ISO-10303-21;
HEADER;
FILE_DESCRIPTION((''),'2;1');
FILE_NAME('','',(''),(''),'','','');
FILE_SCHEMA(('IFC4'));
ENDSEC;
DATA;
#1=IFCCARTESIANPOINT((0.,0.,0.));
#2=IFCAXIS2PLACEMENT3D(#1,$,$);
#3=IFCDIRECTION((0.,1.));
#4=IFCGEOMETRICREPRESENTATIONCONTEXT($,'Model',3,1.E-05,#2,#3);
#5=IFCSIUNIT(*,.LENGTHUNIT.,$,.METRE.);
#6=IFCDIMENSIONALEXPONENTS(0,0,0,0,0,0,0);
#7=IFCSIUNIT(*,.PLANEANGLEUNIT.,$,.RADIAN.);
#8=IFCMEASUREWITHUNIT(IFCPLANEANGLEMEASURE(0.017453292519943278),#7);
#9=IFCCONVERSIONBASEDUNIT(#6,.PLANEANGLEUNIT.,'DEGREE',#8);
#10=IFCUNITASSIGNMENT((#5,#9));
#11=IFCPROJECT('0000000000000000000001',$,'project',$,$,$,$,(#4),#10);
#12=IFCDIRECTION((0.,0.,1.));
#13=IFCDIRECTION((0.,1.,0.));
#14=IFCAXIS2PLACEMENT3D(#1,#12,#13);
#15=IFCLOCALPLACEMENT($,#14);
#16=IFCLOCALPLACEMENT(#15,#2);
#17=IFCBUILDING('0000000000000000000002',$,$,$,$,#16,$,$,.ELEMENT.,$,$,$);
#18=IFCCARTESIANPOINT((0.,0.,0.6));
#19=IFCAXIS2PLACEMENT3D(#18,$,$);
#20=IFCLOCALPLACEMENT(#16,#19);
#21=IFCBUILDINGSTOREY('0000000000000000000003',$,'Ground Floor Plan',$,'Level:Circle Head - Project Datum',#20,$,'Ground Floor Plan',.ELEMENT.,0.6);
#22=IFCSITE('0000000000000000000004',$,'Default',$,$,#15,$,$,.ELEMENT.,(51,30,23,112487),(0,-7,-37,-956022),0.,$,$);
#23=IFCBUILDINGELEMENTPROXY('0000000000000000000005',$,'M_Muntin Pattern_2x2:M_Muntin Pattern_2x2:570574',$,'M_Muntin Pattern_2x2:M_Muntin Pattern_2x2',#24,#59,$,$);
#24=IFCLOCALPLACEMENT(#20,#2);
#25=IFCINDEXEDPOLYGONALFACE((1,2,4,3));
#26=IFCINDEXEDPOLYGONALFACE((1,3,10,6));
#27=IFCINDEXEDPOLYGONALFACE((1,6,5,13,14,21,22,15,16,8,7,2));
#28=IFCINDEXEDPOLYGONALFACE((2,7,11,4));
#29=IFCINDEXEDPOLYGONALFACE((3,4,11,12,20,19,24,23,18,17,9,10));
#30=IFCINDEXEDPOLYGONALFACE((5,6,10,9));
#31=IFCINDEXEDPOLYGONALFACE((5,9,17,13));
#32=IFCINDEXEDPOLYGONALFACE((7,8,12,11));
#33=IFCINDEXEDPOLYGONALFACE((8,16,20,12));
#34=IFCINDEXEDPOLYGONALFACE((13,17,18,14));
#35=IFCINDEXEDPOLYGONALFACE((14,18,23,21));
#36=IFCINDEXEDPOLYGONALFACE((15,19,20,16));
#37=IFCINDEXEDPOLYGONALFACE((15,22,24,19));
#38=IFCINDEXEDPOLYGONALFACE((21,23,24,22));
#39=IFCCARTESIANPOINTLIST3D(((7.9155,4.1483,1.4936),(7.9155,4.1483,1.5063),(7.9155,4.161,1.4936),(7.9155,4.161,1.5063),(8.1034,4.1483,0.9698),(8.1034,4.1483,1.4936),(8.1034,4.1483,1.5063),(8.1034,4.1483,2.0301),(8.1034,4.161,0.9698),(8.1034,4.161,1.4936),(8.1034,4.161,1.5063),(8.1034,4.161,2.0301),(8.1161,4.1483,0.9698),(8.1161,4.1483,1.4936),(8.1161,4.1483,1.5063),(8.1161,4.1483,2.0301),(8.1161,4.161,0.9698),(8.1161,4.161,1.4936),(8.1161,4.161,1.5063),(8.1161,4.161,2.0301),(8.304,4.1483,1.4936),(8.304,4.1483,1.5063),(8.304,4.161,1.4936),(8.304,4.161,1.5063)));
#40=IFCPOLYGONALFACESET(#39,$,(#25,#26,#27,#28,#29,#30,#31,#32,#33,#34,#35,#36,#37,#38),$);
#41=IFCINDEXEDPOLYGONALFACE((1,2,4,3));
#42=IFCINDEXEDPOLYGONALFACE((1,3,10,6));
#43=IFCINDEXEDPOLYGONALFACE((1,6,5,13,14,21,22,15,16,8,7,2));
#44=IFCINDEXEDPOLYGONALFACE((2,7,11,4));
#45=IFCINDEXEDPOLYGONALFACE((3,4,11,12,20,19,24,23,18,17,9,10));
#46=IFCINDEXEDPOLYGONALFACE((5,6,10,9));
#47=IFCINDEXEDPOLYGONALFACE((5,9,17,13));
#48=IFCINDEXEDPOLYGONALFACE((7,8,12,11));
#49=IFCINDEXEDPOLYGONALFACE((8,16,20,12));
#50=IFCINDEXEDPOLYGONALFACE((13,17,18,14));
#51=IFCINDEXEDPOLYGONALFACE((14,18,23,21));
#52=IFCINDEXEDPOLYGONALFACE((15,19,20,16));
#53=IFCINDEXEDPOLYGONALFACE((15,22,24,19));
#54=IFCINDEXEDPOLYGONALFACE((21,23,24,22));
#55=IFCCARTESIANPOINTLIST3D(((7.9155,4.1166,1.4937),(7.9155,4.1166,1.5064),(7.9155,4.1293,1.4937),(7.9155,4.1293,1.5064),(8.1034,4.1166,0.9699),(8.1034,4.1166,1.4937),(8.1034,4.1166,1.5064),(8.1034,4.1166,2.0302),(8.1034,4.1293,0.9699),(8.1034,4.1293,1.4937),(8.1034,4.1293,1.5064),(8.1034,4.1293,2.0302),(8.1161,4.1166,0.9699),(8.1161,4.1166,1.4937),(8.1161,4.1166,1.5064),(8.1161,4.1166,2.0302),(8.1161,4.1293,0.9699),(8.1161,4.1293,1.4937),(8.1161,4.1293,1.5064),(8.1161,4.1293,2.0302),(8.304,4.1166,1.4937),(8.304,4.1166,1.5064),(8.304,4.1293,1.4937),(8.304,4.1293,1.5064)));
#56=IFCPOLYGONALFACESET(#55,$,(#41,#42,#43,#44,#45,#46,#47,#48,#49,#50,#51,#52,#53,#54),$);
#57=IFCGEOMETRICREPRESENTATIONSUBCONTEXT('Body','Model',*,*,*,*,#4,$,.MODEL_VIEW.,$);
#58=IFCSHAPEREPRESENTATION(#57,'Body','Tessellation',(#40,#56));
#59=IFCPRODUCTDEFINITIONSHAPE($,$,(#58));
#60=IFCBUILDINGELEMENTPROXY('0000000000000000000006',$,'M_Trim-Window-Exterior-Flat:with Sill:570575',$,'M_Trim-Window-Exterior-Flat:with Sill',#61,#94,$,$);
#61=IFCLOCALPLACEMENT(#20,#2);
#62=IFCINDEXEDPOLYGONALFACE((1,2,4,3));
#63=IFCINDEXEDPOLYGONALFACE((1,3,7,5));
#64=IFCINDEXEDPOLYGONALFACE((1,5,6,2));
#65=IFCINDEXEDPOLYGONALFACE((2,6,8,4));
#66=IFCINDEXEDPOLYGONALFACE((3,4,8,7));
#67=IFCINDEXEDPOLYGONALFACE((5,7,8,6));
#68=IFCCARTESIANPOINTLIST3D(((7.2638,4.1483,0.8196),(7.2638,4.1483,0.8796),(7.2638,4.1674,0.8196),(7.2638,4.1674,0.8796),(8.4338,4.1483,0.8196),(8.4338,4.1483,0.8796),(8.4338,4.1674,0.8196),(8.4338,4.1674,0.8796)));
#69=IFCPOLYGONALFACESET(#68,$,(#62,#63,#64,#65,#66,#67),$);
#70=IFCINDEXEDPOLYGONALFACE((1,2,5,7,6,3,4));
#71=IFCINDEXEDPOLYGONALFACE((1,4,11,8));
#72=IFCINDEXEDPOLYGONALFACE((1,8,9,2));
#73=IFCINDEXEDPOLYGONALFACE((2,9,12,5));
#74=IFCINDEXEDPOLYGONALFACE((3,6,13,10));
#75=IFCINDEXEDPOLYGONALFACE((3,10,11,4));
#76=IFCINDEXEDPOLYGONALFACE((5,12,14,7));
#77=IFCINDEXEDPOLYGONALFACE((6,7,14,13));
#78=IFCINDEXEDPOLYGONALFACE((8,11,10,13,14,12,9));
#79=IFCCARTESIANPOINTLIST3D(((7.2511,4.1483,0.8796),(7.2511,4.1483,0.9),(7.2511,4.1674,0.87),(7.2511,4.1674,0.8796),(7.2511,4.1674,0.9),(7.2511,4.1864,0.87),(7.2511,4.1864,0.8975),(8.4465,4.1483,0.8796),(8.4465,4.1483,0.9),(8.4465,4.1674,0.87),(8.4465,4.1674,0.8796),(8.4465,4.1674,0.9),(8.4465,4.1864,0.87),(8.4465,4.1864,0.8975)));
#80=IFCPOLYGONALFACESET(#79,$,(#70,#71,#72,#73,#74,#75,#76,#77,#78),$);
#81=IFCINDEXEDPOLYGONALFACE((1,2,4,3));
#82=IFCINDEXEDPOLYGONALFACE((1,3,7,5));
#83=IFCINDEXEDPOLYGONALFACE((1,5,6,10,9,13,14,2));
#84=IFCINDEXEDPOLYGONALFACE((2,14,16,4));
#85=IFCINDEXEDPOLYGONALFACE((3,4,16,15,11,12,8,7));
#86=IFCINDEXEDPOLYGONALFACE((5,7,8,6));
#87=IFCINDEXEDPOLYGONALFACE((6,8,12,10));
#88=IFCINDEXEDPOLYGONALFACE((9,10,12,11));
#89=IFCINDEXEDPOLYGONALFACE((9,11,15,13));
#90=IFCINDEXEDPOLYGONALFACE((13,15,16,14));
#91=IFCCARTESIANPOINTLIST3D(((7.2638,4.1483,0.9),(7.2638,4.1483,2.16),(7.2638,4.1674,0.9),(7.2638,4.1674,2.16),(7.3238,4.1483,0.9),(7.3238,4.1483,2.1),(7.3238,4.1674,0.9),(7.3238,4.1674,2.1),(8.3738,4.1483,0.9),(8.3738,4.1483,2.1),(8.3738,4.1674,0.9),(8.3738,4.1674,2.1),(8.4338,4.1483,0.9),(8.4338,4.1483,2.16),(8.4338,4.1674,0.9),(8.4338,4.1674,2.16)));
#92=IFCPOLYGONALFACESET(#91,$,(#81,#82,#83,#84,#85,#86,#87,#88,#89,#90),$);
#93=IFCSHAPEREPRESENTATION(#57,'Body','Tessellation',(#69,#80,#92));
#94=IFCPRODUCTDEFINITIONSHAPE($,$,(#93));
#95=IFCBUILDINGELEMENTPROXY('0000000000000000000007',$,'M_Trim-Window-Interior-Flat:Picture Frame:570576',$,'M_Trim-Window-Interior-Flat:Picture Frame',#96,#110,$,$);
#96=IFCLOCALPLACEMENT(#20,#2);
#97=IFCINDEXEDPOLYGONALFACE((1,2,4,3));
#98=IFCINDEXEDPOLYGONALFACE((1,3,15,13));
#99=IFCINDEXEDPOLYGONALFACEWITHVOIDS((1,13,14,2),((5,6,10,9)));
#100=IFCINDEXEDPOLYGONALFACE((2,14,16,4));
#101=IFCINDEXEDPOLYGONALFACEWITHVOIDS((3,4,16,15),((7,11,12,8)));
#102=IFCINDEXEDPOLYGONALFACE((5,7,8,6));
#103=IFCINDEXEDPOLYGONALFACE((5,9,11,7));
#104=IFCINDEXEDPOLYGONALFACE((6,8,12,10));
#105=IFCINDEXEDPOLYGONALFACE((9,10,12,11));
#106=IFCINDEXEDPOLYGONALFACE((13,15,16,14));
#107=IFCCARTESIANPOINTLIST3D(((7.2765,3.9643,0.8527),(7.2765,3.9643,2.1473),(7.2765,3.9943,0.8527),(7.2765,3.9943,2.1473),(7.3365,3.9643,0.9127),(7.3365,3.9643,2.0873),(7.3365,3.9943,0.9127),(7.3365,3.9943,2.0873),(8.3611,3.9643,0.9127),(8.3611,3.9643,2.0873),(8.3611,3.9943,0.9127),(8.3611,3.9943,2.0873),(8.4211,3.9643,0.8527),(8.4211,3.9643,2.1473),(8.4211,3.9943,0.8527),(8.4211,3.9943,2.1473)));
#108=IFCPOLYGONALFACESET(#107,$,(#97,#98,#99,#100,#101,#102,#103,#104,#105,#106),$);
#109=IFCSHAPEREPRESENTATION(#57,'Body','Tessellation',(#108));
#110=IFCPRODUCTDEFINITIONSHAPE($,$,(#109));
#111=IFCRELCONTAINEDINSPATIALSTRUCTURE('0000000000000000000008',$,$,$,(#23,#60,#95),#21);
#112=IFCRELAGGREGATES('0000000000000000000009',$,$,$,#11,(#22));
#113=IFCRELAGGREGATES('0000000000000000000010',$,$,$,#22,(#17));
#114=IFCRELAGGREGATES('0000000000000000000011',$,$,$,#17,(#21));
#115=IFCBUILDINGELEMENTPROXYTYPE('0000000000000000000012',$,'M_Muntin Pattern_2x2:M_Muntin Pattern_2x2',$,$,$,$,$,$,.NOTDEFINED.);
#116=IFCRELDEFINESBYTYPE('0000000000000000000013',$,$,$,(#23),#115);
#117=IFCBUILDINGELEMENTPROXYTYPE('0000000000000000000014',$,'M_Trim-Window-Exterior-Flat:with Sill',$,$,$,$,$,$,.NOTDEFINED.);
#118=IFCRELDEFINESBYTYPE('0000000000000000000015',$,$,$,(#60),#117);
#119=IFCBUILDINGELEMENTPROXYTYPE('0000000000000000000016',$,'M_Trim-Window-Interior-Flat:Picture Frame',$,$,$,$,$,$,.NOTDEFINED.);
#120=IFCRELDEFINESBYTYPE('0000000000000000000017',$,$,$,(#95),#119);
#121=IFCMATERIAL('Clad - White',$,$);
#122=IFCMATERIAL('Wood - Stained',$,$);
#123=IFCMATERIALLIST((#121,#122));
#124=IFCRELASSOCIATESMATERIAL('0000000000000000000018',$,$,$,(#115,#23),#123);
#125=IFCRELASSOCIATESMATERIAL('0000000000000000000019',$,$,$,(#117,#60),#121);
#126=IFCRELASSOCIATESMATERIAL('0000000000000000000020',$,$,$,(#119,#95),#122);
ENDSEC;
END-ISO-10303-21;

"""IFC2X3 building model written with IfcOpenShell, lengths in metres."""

from ifc_helpers import new_model, entity, si_unit, converted_unit, direction, frame, frame_2d, origin, place, context, subcontext, project, spatial, polyline, rectangle, outline, extrude, source, transform, mapped, material, material_list, type_object, type_shapes, element, save


model = new_model("IFC2X3")

# Units and contexts
model_context = context("Model", 3, precision=1e-05, world=origin(), true_north=direction((0.0, 1.0)))
body_context = subcontext(model_context, "Body", "Model", "MODEL_VIEW")
ifc_project = project(units=[si_unit("LENGTHUNIT", "METRE"), converted_unit("PLANEANGLEUNIT", "DEGREE", entity("IfcPlaneAngleMeasure", 0.017453292519943278), si_unit("PLANEANGLEUNIT", "RADIAN"), dimensions=[0, 0, 0, 0, 0, 0, 0])], contexts=[model_context])

# Site, building, storey
site_placement = place(None, frame((0.0, 0.0, 0.0), z_axis=(0.0, 0.0, 1.0), x_axis=(0.0, 1.0, 0.0)))
site = spatial("IfcSite", under=ifc_project, at=site_placement, Name="Default", CompositionType="ELEMENT", RefLatitude=(51, 30, 23, 112487), RefLongitude=(0, -7, -37, -956022), RefElevation=0.0)
building_placement = place(site_placement, origin())
building = spatial("IfcBuilding", under=site, at=building_placement, CompositionType="ELEMENT")
storey_placement = place(building_placement, frame((0.0, 0.0, 0.6)))
storey = spatial("IfcBuildingStorey", under=building, at=storey_placement, Name="Ground Floor Plan", ObjectType="Level:Circle Head - Project Datum", LongName="Ground Floor Plan", CompositionType="ELEMENT", Elevation=0.6)

# Building element proxies
ifc_material_1 = material(Name="Clad - White")
ifc_material_2 = material(Name="Wood - Stained")
ifc_material_list = material_list([ifc_material_1, ifc_material_2])
building_element_proxy_type_1 = type_object("IfcBuildingElementProxyType", Name="M_Muntin Pattern_2x2:M_Muntin Pattern_2x2", PredefinedType="NOTDEFINED", material=ifc_material_list)
shared_shape_1 = source(origin(), body_context, "Body", "SweptSolid", [
    extrude(outline(polyline([(0.0064, -0.0064), (0.5301, -0.0064), (0.5301, 0.0063), (0.0064, 0.0063), (0.0064, 0.1942), (-0.0063, 0.1942), (-0.0063, 0.0063), (-0.5302, 0.0063), (-0.5302, -0.0064), (-0.0063, -0.0064), (-0.0063, -0.1942), (0.0064, -0.1942), (0.0064, -0.0064)])), frame((0.0, -0.0222, 0.5301), z_axis=(0.0, 1.0, 0.0), x_axis=(0.0, 0.0, 1.0)), (0.0, 0.0, 1.0), 0.0127),
    extrude(outline(polyline([(0.0064, -0.0064), (0.5302, -0.0064), (0.5302, 0.0063), (0.0064, 0.0063), (0.0064, 0.1942), (-0.0063, 0.1942), (-0.0063, 0.0063), (-0.5302, 0.0063), (-0.5302, -0.0064), (-0.0063, -0.0064), (-0.0063, -0.1942), (0.0064, -0.1942), (0.0064, -0.0064)])), frame((0.0, 0.0095, 0.5302), z_axis=(0.0, 1.0, 0.0), x_axis=(0.0, 0.0, 1.0)), (0.0, 0.0, 1.0), 0.0127),
])
type_shapes(building_element_proxy_type_1, [shared_shape_1])
proxy_1_placement = place(storey_placement, frame((8.1098, 4.1388, 0.9699), z_axis=(0.0, 0.0, 1.0), x_axis=(-1.0, 0.0, 0.0)))
element("IfcBuildingElementProxy", 1, at=proxy_1_placement, inside=storey, type_object=building_element_proxy_type_1, material=ifc_material_list, Name="M_Muntin Pattern_2x2:M_Muntin Pattern_2x2:570574", ObjectType="M_Muntin Pattern_2x2:M_Muntin Pattern_2x2", context=body_context, shape_type="MappedRepresentation", body=[
    mapped(shared_shape_1, transform((0.0, 0.0, 0.0), scale=1.0)),
])
building_element_proxy_type_2 = type_object("IfcBuildingElementProxyType", Name="M_Trim-Window-Exterior-Flat:with Sill", PredefinedType="NOTDEFINED", material=ifc_material_1)
shared_shape_2 = source(origin(), body_context, "Body", "SweptSolid", [
    extrude(rectangle(XDim=1.17, YDim=0.06, at=frame_2d((0.0, 0.0), x_axis=(1.0, 0.0))), frame((0.0, -1.2504, 0.0), z_axis=(0.0, 0.0, 1.0), x_axis=(-1.0, 0.0, 0.0)), (0.0, 0.0, 1.0), 0.019),
    extrude(outline(polyline([(-0.019, -0.0152), (0.0, -0.0152), (0.0, -0.0057), (0.019, -0.0057), (0.019, 0.0148), (0.0, 0.0148), (-0.019, 0.0123), (-0.019, -0.0152)])), frame((-0.5977, -1.2148, 0.019), z_axis=(1.0, 0.0, 0.0), x_axis=(0.0, 0.0, -1.0)), (0.0, 0.0, 1.0), 1.1954),
    extrude(outline(polyline([(-0.645, -0.585), (0.615, -0.585), (0.615, -0.525), (-0.585, -0.525), (-0.585, 0.525), (0.615, 0.525), (0.615, 0.585), (-0.645, 0.585), (-0.645, -0.585)])), frame((0.0, -0.585, 0.0), z_axis=(0.0, 0.0, 1.0), x_axis=(0.0, -1.0, 0.0)), (0.0, 0.0, 1.0), 0.019),
])
type_shapes(building_element_proxy_type_2, [shared_shape_2])
proxy_2_placement = place(storey_placement, frame((7.8488, 4.1483, 2.1), z_axis=(0.0, 1.0, 0.0), x_axis=(-1.0, 0.0, 0.0)))
element("IfcBuildingElementProxy", 2, at=proxy_2_placement, inside=storey, type_object=building_element_proxy_type_2, material=ifc_material_1, Name="M_Trim-Window-Exterior-Flat:with Sill:570575", ObjectType="M_Trim-Window-Exterior-Flat:with Sill", context=body_context, shape_type="MappedRepresentation", body=[
    mapped(shared_shape_2, transform((0.0, 0.0, 0.0), scale=1.0)),
])
building_element_proxy_type_3 = type_object("IfcBuildingElementProxyType", Name="M_Trim-Window-Interior-Flat:Picture Frame", PredefinedType="NOTDEFINED", material=ifc_material_2)
shared_shape_3 = source(origin(), body_context, "Body", "SweptSolid", [
    extrude(outline(polyline([(-0.5723, -0.6473), (0.5723, -0.6473), (0.5723, 0.6473), (-0.5723, 0.6473), (-0.5723, -0.6473)]), holes=[polyline([(-0.5123, -0.5873), (-0.5123, 0.5873), (0.5123, 0.5873), (0.5123, -0.5873), (-0.5123, -0.5873)])]), frame((0.0, -0.6, 0.0), z_axis=(0.0, 0.0, 1.0), x_axis=(-1.0, 0.0, 0.0)), (0.0, 0.0, 1.0), 0.03),
])
type_shapes(building_element_proxy_type_3, [shared_shape_3])
proxy_3_placement = place(storey_placement, frame((7.8488, 3.9943, 2.1), z_axis=(0.0, -1.0, 0.0), x_axis=(1.0, 0.0, 0.0)))
element("IfcBuildingElementProxy", 3, at=proxy_3_placement, inside=storey, type_object=building_element_proxy_type_3, material=ifc_material_2, Name="M_Trim-Window-Interior-Flat:Picture Frame:570576", ObjectType="M_Trim-Window-Interior-Flat:Picture Frame", context=body_context, shape_type="MappedRepresentation", body=[
    mapped(shared_shape_3, transform((0.0, 0.0, 0.0), scale=1.0)),
])

save(model, "model.ifc")
